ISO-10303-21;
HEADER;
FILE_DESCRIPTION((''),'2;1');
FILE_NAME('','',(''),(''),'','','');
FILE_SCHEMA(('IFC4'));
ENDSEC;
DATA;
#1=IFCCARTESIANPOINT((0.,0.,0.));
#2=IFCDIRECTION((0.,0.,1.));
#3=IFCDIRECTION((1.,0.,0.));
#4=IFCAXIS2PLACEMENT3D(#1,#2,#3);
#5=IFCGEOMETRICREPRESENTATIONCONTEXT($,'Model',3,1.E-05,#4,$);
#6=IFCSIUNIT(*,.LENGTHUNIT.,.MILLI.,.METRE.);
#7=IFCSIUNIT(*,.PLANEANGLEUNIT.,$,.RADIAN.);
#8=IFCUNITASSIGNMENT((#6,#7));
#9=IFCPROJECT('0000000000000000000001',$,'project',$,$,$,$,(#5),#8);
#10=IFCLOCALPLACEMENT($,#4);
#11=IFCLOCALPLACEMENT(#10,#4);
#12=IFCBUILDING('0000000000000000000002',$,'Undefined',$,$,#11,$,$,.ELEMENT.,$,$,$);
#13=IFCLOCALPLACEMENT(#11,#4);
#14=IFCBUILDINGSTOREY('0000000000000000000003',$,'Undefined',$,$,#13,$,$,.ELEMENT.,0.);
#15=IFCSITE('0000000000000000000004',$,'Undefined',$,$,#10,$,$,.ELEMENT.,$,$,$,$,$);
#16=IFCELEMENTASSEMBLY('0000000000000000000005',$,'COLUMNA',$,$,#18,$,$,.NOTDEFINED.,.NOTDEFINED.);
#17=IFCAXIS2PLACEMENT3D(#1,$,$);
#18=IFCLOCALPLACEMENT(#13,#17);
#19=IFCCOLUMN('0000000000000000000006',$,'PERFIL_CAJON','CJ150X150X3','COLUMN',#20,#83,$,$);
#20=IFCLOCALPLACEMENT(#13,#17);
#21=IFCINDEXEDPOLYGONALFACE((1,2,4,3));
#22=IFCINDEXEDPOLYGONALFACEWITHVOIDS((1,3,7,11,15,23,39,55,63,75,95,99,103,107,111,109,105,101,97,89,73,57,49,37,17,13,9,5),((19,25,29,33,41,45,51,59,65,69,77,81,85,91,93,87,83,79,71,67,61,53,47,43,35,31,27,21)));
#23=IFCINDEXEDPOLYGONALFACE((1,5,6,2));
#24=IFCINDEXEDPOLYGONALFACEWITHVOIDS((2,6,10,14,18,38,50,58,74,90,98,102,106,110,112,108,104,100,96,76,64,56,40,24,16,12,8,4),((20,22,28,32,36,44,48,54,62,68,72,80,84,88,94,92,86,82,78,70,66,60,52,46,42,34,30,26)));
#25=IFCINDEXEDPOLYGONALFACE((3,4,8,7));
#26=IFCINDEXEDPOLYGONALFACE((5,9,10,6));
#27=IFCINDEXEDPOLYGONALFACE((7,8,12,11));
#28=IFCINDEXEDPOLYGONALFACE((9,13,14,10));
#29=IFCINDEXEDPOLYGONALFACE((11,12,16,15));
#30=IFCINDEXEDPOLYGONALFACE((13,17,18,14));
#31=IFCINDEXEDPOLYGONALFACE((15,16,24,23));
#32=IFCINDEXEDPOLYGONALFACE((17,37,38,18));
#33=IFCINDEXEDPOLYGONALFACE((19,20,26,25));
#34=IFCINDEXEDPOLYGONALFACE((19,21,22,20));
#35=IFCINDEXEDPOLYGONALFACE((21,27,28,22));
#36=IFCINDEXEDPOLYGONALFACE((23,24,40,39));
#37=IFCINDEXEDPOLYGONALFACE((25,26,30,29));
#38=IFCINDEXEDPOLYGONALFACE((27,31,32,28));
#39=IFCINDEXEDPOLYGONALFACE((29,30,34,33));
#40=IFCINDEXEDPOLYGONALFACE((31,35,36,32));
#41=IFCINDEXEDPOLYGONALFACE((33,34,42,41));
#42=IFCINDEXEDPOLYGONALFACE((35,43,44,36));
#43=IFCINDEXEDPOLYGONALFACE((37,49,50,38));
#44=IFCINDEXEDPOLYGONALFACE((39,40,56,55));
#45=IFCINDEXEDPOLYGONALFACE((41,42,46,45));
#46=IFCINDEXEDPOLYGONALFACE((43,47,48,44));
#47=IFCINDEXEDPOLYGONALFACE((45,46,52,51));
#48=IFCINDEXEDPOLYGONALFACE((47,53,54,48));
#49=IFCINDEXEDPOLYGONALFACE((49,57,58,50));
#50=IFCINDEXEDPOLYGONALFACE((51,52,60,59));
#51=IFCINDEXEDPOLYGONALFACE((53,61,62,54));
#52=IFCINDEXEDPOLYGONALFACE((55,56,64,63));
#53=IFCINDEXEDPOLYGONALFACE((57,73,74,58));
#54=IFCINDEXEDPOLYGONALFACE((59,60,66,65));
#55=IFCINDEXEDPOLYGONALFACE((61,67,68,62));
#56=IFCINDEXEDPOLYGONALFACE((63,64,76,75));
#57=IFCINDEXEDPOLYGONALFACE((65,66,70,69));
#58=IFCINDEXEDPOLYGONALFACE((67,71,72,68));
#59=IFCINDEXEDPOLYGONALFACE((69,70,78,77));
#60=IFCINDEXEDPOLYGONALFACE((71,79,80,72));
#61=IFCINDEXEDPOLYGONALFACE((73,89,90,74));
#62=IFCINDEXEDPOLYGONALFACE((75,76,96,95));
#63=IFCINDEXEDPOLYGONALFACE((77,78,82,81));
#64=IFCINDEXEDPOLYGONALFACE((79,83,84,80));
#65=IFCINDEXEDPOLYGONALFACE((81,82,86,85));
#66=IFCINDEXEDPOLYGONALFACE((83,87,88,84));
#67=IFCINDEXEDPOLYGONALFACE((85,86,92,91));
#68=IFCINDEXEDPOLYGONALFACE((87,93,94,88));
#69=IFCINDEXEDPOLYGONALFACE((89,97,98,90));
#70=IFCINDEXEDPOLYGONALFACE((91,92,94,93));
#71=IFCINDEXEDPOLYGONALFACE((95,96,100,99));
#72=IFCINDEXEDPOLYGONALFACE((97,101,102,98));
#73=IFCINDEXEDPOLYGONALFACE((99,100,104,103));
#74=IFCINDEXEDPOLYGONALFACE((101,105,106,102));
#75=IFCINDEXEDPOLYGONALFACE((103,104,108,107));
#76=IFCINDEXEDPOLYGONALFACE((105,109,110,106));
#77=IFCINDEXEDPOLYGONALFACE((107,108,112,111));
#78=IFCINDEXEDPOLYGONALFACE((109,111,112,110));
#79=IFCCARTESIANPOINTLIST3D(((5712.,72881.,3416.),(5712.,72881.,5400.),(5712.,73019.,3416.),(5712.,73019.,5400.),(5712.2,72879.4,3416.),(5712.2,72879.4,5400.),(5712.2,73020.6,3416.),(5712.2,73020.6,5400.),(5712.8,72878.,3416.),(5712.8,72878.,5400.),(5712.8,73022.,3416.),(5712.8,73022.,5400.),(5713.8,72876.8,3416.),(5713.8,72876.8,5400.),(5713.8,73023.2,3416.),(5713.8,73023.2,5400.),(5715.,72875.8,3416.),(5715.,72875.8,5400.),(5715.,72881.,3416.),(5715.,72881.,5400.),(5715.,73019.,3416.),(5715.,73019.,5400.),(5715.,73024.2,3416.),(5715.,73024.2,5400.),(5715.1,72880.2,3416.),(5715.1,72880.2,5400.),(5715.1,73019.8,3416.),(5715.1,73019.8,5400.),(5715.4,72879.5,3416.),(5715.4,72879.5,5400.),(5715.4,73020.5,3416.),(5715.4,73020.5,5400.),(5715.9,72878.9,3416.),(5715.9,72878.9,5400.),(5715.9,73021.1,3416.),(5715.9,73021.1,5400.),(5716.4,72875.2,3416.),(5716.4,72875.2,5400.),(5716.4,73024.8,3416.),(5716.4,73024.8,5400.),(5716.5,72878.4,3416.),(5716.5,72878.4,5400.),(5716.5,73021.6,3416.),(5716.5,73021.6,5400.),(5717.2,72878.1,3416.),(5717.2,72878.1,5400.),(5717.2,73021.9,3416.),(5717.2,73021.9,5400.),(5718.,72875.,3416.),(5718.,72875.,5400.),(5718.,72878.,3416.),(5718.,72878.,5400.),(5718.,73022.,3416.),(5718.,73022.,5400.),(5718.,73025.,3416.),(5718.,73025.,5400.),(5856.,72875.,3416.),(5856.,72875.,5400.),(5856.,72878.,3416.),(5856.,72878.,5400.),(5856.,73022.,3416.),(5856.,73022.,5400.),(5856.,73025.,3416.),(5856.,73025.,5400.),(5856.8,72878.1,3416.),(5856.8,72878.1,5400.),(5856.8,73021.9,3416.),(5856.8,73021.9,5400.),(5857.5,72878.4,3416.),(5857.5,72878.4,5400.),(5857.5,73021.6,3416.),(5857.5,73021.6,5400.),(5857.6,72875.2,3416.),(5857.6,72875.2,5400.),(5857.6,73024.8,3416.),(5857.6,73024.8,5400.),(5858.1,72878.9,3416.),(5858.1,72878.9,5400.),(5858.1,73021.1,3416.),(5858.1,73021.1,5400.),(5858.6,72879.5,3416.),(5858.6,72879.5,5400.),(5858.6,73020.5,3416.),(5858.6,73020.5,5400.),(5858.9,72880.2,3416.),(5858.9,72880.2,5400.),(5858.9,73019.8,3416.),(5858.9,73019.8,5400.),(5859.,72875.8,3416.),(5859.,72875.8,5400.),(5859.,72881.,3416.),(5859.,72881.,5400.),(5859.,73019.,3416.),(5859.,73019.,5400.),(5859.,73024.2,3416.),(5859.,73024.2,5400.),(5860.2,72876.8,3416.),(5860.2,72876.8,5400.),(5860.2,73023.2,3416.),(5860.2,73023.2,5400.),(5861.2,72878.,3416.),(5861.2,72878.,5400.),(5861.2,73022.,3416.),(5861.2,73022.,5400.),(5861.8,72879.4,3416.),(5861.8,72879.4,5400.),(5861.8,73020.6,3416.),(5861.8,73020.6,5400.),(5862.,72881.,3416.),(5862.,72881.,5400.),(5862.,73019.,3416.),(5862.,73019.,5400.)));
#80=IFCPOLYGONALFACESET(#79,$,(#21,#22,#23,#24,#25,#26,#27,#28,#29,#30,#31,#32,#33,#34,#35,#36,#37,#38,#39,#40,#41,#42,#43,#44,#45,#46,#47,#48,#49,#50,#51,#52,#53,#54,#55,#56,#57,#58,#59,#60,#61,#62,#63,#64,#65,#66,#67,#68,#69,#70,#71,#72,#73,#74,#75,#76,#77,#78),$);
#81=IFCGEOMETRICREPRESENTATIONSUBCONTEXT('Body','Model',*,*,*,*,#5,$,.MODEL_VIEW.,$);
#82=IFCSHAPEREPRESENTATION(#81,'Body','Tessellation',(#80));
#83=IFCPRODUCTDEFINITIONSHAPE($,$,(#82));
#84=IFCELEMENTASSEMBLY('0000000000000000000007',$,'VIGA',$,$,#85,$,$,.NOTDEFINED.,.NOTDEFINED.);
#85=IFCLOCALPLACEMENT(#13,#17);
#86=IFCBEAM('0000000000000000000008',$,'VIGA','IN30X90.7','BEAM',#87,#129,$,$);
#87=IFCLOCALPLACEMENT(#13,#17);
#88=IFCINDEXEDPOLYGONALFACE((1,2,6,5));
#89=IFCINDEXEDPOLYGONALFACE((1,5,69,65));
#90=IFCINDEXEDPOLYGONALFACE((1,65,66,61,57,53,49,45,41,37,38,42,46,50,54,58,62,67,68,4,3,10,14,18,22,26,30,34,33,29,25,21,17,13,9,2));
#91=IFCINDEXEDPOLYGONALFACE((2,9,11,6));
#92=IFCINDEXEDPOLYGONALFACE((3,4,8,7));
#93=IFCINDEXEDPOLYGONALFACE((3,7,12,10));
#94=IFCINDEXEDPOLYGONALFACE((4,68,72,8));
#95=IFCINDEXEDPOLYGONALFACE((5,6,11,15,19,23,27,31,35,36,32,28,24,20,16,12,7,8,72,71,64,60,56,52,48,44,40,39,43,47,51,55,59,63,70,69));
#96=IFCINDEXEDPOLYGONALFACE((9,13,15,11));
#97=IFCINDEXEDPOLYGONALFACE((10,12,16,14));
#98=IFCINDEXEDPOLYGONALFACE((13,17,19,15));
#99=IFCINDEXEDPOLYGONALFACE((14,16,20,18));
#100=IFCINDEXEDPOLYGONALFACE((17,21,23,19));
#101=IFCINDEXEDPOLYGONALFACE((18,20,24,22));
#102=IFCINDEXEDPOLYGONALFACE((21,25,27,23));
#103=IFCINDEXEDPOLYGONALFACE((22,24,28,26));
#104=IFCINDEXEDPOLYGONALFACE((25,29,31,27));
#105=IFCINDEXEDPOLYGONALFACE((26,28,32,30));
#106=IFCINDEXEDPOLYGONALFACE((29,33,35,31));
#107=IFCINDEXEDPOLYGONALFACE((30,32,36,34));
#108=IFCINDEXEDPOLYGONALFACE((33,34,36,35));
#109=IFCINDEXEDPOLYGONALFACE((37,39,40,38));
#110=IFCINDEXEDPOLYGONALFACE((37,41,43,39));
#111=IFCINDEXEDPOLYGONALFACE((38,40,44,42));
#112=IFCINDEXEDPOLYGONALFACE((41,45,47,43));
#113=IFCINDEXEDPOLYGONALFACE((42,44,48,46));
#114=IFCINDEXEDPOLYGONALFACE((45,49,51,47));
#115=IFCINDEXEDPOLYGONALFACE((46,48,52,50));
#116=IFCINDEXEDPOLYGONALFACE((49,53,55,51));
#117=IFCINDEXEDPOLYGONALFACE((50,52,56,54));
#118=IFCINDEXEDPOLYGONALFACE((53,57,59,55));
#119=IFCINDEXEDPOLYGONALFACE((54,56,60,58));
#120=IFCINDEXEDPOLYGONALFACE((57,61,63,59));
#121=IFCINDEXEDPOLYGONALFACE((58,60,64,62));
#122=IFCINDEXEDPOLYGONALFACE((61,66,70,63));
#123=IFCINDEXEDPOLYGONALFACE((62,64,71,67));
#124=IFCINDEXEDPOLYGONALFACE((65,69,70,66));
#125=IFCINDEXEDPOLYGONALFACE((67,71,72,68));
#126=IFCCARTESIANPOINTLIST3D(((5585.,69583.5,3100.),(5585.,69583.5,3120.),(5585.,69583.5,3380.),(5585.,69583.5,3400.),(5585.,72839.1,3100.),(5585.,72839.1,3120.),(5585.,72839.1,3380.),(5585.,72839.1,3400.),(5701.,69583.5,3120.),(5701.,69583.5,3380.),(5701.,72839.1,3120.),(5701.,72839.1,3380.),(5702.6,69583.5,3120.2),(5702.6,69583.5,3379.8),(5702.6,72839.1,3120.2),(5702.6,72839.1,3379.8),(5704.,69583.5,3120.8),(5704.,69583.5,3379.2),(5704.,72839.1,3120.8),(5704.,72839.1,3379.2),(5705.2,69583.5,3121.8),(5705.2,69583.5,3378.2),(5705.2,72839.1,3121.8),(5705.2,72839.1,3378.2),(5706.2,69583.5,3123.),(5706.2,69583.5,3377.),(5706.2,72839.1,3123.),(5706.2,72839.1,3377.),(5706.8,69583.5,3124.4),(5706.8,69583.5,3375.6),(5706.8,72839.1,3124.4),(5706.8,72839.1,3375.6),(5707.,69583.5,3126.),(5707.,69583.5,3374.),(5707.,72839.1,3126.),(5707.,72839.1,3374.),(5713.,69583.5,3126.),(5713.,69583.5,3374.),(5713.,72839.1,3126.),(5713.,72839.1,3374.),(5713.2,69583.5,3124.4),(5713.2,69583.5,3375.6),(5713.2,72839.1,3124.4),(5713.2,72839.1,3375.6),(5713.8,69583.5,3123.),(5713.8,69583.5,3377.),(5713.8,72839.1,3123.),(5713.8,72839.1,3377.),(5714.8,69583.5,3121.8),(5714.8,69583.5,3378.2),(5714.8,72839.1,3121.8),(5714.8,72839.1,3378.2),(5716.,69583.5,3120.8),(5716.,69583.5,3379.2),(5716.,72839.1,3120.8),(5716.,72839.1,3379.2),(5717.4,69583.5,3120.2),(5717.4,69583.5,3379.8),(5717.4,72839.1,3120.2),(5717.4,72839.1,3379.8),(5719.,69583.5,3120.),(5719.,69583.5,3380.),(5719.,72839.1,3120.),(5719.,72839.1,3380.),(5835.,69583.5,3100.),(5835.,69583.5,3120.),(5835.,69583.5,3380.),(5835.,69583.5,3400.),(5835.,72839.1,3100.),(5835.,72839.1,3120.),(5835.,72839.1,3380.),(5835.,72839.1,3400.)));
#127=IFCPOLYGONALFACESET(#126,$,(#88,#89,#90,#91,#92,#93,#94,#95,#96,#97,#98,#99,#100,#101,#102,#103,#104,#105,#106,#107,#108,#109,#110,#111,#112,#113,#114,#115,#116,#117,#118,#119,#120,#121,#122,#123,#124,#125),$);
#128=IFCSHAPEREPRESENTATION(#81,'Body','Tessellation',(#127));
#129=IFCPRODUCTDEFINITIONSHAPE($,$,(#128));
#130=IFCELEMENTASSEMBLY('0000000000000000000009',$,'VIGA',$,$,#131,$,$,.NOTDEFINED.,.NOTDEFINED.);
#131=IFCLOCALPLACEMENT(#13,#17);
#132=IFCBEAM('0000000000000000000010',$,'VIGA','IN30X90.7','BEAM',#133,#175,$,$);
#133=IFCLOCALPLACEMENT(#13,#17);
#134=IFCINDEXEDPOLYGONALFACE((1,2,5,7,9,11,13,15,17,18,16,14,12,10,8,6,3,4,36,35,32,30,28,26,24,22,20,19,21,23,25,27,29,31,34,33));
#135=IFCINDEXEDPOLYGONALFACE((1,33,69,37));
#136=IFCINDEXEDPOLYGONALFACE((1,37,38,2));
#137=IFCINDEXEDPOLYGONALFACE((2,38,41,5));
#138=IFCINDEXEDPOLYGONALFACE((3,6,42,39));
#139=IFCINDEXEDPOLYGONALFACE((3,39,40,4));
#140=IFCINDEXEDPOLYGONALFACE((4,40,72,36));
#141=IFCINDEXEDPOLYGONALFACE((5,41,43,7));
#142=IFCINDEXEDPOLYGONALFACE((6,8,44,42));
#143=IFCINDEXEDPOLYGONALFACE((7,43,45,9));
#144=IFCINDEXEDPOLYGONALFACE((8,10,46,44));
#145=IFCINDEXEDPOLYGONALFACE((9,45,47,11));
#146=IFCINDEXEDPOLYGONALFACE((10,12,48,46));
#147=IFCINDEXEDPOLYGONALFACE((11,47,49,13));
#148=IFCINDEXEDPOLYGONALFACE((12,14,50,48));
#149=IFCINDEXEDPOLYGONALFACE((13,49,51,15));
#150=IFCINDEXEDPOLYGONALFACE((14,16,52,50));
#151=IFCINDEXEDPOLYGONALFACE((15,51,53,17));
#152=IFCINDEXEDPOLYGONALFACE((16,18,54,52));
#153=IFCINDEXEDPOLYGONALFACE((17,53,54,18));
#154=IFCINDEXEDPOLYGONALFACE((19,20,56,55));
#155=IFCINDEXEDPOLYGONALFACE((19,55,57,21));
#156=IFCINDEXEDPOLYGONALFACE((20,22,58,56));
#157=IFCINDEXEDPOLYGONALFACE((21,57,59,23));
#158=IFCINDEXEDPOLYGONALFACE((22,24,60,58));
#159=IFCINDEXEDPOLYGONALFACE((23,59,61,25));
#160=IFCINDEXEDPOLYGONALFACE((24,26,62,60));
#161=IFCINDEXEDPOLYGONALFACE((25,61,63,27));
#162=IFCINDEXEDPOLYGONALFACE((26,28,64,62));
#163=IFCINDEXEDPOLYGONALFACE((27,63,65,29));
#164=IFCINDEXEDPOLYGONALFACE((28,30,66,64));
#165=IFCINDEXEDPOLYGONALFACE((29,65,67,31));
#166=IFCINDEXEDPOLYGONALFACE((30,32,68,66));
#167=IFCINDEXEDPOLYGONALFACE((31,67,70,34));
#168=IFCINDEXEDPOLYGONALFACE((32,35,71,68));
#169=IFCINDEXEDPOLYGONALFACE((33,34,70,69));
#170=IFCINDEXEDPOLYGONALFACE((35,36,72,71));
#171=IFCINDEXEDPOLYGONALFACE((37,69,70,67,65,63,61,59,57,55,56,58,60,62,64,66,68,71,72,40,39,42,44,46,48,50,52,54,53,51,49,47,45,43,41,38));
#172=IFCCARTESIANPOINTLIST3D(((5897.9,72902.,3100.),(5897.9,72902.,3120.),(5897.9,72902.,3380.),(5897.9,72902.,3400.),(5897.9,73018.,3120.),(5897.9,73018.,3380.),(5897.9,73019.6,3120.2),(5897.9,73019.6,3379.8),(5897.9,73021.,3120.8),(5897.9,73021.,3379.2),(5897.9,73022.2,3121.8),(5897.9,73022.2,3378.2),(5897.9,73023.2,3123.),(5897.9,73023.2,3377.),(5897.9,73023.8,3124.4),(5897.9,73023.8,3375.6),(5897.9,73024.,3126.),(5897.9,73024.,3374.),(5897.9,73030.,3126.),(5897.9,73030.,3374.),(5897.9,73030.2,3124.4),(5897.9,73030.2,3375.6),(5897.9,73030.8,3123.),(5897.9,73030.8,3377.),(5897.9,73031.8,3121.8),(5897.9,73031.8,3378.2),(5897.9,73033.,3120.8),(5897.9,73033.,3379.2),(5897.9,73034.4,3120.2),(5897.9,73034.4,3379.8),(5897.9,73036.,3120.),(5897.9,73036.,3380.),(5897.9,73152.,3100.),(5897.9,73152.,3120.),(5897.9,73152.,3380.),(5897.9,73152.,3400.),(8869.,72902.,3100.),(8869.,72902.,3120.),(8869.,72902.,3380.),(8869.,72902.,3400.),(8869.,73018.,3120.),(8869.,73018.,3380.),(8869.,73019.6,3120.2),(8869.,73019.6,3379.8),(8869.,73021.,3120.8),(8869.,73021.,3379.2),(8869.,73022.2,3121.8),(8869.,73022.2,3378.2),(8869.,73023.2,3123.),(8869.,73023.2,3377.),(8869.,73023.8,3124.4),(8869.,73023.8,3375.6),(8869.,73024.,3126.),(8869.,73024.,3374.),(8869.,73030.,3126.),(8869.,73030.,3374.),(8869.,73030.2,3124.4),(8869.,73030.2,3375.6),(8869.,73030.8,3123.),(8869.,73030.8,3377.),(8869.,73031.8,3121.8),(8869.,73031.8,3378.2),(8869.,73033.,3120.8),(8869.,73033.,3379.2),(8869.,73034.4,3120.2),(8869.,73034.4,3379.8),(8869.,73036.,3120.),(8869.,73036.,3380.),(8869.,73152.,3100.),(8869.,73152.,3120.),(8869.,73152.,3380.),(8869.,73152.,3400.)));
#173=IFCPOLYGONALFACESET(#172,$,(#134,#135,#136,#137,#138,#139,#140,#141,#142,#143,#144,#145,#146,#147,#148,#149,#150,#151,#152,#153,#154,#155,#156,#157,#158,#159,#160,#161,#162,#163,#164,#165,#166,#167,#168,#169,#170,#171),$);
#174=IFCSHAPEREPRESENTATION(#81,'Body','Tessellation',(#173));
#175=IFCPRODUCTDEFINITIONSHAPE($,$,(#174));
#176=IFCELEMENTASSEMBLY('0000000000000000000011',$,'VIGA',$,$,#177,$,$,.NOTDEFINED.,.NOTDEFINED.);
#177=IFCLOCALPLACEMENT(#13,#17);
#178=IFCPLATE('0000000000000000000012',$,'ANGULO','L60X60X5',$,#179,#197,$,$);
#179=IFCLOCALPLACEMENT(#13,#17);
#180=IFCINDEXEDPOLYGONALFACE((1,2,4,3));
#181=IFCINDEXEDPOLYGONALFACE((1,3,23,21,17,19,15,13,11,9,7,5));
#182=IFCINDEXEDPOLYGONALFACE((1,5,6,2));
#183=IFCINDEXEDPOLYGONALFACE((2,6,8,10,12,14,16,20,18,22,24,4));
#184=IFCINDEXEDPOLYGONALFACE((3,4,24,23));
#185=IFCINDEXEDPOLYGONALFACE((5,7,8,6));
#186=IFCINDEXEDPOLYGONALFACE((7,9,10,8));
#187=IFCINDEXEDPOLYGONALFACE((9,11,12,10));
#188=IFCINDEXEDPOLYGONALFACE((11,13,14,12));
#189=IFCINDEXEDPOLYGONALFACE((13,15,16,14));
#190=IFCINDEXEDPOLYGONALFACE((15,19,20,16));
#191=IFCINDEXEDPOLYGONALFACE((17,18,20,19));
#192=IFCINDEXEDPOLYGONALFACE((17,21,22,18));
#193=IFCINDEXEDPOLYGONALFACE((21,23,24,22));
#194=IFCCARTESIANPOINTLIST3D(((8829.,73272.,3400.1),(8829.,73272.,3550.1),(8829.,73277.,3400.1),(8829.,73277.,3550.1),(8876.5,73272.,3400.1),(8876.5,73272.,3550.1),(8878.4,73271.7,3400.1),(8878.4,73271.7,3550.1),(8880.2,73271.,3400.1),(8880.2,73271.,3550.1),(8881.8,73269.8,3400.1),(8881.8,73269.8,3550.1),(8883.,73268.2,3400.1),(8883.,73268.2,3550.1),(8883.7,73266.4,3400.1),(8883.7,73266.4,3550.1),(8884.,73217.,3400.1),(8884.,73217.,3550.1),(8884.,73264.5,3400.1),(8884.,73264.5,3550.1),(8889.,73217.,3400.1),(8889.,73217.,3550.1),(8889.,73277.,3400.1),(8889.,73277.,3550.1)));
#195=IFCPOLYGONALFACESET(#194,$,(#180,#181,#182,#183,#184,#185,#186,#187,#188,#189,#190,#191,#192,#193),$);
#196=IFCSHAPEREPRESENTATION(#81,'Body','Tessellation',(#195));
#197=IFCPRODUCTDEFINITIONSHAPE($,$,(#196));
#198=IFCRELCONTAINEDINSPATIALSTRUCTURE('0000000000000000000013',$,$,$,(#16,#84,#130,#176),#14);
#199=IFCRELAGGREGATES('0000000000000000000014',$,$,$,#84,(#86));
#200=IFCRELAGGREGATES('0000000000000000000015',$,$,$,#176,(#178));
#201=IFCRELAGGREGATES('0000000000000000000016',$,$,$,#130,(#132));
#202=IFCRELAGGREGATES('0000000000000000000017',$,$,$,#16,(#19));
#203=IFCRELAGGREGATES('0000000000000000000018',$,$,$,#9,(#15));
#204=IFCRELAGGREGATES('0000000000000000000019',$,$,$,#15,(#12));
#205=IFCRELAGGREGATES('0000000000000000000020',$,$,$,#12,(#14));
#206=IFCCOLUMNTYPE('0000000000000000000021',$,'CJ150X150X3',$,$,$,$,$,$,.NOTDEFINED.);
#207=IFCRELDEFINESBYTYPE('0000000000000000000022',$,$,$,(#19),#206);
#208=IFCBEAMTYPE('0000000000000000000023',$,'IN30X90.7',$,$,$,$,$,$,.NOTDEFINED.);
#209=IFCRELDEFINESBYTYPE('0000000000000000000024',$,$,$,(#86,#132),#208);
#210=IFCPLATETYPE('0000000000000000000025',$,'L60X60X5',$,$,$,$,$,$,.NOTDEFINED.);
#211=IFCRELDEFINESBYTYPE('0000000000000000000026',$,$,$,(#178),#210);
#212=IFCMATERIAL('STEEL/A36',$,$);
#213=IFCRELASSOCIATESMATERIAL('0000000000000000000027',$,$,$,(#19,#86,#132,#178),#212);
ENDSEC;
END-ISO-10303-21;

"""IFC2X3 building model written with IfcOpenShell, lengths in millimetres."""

from ifc_helpers import new_model, si_unit, frame, origin_with_axes, origin_2d_with_axis, place, context, subcontext, project, spatial, hollow_rectangle, i_section, l_section, extrude, clip, halfspace, material, type_object, element, aggregate, save


model = new_model("IFC2X3")

# Units and contexts
model_context = context("Model", 3, precision=1e-05, world=origin_with_axes())
body_context = subcontext(model_context, "Body", "Model", "MODEL_VIEW")
ifc_project = project(units=[si_unit("LENGTHUNIT", "METRE", prefix="MILLI"), si_unit("PLANEANGLEUNIT", "RADIAN")], contexts=[model_context])

# Site, building, storey
site_placement = place(None, origin_with_axes())
site = spatial("IfcSite", under=ifc_project, at=site_placement, Name="Undefined", CompositionType="ELEMENT")
building_placement = place(site_placement, origin_with_axes())
building = spatial("IfcBuilding", under=site, at=building_placement, Name="Undefined", CompositionType="ELEMENT")
storey_placement = place(building_placement, origin_with_axes())
storey = spatial("IfcBuildingStorey", under=building, at=storey_placement, Name="Undefined", CompositionType="ELEMENT", Elevation=0.0)

# Element assembly, column
assembly_1_placement = place(storey_placement, origin_with_axes())
assembly_1 = element("IfcElementAssembly", 1, at=assembly_1_placement, inside=storey, Name="COLUMNA", AssemblyPlace="NOTDEFINED", PredefinedType="NOTDEFINED")
ifc_material_1 = material(Name="STEEL/A36")
column_type = type_object("IfcColumnType", Name="CJ150X150X3", PredefinedType="NOTDEFINED")
column_placement = place(assembly_1_placement, frame((5787.0, 72950.0, 3416.0), z_axis=(0.0, 0.0, 1.0), x_axis=(-1.0, 0.0, 0.0)))
column = element("IfcColumn", 2, at=column_placement, type_object=column_type, material=ifc_material_1, Name="PERFIL_CAJON", Description="CJ150X150X3", ObjectType="COLUMN", context=body_context, shape_type="SweptSolid", body=[
    extrude(hollow_rectangle(XDim=150.0, YDim=150.0, WallThickness=3.0, InnerFilletRadius=3.0, OuterFilletRadius=6.0, at=origin_2d_with_axis()), frame((0.0, 0.0, 1984.0), z_axis=(0.0, 0.0, -1.0), x_axis=(0.0, 1.0, 0.0)), (0.0, 0.0, 1.0), 1984.0),
])

# Element assemblies, beams
assembly_2_placement = place(storey_placement, origin_with_axes())
assembly_2 = element("IfcElementAssembly", 3, at=assembly_2_placement, inside=storey, Name="VIGA", AssemblyPlace="NOTDEFINED", PredefinedType="NOTDEFINED")
beam_type_1 = type_object("IfcBeamType", Name="IN30X90.7", PredefinedType="NOTDEFINED")
beam_1_placement = place(assembly_2_placement, frame((5710.0, 72839.1, 3250.0), z_axis=(0.0, 0.0, 1.0), x_axis=(0.0, -1.0, 0.0)))
beam_1 = element("IfcBeam", 4, at=beam_1_placement, type_object=beam_type_1, material=ifc_material_1, Name="VIGA", Description="IN30X90.7", ObjectType="BEAM", context=body_context, shape_type="Clipping", body=[
    clip(extrude(i_section(OverallWidth=250.0, OverallDepth=300.0, WebThickness=6.0, FlangeThickness=20.0, FilletRadius=6.0, at=origin_2d_with_axis()), frame((3515.6, 0.0, 0.0), z_axis=(-1.0, 0.0, 0.0), x_axis=(0.0, -1.0, 0.0)), (0.0, 0.0, 1.0), 3515.6), halfspace(frame((3255.6, 0.0, 250.0), z_axis=(1.0, 0.0, 0.0), x_axis=(0.0, 1.0, 0.0)), False)),
])
aggregate(assembly_2, [beam_1])
assembly_3_placement = place(storey_placement, origin_with_axes())
assembly_3 = element("IfcElementAssembly", 5, at=assembly_3_placement, inside=storey, Name="VIGA", AssemblyPlace="NOTDEFINED", PredefinedType="NOTDEFINED")
beam_2_placement = place(assembly_3_placement, frame((5897.9, 73027.0, 3250.0), z_axis=(0.0, 0.0, 1.0), x_axis=(1.0, 0.0, 0.0)))
beam_2 = element("IfcBeam", 6, at=beam_2_placement, type_object=beam_type_1, material=ifc_material_1, Name="VIGA", Description="IN30X90.7", ObjectType="BEAM", context=body_context, shape_type="Clipping", body=[
    clip(extrude(i_section(OverallWidth=250.0, OverallDepth=300.0, WebThickness=6.0, FlangeThickness=20.0, FilletRadius=6.0, at=origin_2d_with_axis()), frame((2981.1, 0.0, 0.0), z_axis=(-1.0, 0.0, 0.0), x_axis=(0.0, -1.0, 0.0)), (0.0, 0.0, 1.0), 2981.1), halfspace(frame((2971.1, 0.0, 250.0), z_axis=(1.0, 0.0, 0.0), x_axis=(0.0, 1.0, 0.0)), False)),
])

# Element assembly, plate
assembly_4_placement = place(storey_placement, origin_with_axes())
assembly_4 = element("IfcElementAssembly", 7, at=assembly_4_placement, inside=storey, Name="VIGA", AssemblyPlace="NOTDEFINED", PredefinedType="NOTDEFINED")
plate_type_1 = type_object("IfcPlateType", Name="L60X60X5", PredefinedType="NOTDEFINED")
plate_1_placement = place(assembly_4_placement, frame((8859.0, 73247.0, 3400.1), z_axis=(-1.0, 0.0, 0.0), x_axis=(0.0, 0.0, 1.0)))
plate_1 = element("IfcPlate", 8, at=plate_1_placement, type_object=plate_type_1, material=ifc_material_1, Name="ANGULO", Description="L60X60X5", context=body_context, shape_type="SweptSolid", body=[
    extrude(l_section(Depth=60.0, Width=60.0, Thickness=5.0, FilletRadius=7.5, at=origin_2d_with_axis()), frame((150.0, 0.0, 0.0), z_axis=(-1.0, 0.0, 0.0), x_axis=(0.0, -1.0, 0.0)), (0.0, 0.0, 1.0), 150.0),
])

aggregate(assembly_4, [plate_1])

aggregate(assembly_3, [beam_2])
aggregate(assembly_1, [column])

save(model, "model.ifc")
